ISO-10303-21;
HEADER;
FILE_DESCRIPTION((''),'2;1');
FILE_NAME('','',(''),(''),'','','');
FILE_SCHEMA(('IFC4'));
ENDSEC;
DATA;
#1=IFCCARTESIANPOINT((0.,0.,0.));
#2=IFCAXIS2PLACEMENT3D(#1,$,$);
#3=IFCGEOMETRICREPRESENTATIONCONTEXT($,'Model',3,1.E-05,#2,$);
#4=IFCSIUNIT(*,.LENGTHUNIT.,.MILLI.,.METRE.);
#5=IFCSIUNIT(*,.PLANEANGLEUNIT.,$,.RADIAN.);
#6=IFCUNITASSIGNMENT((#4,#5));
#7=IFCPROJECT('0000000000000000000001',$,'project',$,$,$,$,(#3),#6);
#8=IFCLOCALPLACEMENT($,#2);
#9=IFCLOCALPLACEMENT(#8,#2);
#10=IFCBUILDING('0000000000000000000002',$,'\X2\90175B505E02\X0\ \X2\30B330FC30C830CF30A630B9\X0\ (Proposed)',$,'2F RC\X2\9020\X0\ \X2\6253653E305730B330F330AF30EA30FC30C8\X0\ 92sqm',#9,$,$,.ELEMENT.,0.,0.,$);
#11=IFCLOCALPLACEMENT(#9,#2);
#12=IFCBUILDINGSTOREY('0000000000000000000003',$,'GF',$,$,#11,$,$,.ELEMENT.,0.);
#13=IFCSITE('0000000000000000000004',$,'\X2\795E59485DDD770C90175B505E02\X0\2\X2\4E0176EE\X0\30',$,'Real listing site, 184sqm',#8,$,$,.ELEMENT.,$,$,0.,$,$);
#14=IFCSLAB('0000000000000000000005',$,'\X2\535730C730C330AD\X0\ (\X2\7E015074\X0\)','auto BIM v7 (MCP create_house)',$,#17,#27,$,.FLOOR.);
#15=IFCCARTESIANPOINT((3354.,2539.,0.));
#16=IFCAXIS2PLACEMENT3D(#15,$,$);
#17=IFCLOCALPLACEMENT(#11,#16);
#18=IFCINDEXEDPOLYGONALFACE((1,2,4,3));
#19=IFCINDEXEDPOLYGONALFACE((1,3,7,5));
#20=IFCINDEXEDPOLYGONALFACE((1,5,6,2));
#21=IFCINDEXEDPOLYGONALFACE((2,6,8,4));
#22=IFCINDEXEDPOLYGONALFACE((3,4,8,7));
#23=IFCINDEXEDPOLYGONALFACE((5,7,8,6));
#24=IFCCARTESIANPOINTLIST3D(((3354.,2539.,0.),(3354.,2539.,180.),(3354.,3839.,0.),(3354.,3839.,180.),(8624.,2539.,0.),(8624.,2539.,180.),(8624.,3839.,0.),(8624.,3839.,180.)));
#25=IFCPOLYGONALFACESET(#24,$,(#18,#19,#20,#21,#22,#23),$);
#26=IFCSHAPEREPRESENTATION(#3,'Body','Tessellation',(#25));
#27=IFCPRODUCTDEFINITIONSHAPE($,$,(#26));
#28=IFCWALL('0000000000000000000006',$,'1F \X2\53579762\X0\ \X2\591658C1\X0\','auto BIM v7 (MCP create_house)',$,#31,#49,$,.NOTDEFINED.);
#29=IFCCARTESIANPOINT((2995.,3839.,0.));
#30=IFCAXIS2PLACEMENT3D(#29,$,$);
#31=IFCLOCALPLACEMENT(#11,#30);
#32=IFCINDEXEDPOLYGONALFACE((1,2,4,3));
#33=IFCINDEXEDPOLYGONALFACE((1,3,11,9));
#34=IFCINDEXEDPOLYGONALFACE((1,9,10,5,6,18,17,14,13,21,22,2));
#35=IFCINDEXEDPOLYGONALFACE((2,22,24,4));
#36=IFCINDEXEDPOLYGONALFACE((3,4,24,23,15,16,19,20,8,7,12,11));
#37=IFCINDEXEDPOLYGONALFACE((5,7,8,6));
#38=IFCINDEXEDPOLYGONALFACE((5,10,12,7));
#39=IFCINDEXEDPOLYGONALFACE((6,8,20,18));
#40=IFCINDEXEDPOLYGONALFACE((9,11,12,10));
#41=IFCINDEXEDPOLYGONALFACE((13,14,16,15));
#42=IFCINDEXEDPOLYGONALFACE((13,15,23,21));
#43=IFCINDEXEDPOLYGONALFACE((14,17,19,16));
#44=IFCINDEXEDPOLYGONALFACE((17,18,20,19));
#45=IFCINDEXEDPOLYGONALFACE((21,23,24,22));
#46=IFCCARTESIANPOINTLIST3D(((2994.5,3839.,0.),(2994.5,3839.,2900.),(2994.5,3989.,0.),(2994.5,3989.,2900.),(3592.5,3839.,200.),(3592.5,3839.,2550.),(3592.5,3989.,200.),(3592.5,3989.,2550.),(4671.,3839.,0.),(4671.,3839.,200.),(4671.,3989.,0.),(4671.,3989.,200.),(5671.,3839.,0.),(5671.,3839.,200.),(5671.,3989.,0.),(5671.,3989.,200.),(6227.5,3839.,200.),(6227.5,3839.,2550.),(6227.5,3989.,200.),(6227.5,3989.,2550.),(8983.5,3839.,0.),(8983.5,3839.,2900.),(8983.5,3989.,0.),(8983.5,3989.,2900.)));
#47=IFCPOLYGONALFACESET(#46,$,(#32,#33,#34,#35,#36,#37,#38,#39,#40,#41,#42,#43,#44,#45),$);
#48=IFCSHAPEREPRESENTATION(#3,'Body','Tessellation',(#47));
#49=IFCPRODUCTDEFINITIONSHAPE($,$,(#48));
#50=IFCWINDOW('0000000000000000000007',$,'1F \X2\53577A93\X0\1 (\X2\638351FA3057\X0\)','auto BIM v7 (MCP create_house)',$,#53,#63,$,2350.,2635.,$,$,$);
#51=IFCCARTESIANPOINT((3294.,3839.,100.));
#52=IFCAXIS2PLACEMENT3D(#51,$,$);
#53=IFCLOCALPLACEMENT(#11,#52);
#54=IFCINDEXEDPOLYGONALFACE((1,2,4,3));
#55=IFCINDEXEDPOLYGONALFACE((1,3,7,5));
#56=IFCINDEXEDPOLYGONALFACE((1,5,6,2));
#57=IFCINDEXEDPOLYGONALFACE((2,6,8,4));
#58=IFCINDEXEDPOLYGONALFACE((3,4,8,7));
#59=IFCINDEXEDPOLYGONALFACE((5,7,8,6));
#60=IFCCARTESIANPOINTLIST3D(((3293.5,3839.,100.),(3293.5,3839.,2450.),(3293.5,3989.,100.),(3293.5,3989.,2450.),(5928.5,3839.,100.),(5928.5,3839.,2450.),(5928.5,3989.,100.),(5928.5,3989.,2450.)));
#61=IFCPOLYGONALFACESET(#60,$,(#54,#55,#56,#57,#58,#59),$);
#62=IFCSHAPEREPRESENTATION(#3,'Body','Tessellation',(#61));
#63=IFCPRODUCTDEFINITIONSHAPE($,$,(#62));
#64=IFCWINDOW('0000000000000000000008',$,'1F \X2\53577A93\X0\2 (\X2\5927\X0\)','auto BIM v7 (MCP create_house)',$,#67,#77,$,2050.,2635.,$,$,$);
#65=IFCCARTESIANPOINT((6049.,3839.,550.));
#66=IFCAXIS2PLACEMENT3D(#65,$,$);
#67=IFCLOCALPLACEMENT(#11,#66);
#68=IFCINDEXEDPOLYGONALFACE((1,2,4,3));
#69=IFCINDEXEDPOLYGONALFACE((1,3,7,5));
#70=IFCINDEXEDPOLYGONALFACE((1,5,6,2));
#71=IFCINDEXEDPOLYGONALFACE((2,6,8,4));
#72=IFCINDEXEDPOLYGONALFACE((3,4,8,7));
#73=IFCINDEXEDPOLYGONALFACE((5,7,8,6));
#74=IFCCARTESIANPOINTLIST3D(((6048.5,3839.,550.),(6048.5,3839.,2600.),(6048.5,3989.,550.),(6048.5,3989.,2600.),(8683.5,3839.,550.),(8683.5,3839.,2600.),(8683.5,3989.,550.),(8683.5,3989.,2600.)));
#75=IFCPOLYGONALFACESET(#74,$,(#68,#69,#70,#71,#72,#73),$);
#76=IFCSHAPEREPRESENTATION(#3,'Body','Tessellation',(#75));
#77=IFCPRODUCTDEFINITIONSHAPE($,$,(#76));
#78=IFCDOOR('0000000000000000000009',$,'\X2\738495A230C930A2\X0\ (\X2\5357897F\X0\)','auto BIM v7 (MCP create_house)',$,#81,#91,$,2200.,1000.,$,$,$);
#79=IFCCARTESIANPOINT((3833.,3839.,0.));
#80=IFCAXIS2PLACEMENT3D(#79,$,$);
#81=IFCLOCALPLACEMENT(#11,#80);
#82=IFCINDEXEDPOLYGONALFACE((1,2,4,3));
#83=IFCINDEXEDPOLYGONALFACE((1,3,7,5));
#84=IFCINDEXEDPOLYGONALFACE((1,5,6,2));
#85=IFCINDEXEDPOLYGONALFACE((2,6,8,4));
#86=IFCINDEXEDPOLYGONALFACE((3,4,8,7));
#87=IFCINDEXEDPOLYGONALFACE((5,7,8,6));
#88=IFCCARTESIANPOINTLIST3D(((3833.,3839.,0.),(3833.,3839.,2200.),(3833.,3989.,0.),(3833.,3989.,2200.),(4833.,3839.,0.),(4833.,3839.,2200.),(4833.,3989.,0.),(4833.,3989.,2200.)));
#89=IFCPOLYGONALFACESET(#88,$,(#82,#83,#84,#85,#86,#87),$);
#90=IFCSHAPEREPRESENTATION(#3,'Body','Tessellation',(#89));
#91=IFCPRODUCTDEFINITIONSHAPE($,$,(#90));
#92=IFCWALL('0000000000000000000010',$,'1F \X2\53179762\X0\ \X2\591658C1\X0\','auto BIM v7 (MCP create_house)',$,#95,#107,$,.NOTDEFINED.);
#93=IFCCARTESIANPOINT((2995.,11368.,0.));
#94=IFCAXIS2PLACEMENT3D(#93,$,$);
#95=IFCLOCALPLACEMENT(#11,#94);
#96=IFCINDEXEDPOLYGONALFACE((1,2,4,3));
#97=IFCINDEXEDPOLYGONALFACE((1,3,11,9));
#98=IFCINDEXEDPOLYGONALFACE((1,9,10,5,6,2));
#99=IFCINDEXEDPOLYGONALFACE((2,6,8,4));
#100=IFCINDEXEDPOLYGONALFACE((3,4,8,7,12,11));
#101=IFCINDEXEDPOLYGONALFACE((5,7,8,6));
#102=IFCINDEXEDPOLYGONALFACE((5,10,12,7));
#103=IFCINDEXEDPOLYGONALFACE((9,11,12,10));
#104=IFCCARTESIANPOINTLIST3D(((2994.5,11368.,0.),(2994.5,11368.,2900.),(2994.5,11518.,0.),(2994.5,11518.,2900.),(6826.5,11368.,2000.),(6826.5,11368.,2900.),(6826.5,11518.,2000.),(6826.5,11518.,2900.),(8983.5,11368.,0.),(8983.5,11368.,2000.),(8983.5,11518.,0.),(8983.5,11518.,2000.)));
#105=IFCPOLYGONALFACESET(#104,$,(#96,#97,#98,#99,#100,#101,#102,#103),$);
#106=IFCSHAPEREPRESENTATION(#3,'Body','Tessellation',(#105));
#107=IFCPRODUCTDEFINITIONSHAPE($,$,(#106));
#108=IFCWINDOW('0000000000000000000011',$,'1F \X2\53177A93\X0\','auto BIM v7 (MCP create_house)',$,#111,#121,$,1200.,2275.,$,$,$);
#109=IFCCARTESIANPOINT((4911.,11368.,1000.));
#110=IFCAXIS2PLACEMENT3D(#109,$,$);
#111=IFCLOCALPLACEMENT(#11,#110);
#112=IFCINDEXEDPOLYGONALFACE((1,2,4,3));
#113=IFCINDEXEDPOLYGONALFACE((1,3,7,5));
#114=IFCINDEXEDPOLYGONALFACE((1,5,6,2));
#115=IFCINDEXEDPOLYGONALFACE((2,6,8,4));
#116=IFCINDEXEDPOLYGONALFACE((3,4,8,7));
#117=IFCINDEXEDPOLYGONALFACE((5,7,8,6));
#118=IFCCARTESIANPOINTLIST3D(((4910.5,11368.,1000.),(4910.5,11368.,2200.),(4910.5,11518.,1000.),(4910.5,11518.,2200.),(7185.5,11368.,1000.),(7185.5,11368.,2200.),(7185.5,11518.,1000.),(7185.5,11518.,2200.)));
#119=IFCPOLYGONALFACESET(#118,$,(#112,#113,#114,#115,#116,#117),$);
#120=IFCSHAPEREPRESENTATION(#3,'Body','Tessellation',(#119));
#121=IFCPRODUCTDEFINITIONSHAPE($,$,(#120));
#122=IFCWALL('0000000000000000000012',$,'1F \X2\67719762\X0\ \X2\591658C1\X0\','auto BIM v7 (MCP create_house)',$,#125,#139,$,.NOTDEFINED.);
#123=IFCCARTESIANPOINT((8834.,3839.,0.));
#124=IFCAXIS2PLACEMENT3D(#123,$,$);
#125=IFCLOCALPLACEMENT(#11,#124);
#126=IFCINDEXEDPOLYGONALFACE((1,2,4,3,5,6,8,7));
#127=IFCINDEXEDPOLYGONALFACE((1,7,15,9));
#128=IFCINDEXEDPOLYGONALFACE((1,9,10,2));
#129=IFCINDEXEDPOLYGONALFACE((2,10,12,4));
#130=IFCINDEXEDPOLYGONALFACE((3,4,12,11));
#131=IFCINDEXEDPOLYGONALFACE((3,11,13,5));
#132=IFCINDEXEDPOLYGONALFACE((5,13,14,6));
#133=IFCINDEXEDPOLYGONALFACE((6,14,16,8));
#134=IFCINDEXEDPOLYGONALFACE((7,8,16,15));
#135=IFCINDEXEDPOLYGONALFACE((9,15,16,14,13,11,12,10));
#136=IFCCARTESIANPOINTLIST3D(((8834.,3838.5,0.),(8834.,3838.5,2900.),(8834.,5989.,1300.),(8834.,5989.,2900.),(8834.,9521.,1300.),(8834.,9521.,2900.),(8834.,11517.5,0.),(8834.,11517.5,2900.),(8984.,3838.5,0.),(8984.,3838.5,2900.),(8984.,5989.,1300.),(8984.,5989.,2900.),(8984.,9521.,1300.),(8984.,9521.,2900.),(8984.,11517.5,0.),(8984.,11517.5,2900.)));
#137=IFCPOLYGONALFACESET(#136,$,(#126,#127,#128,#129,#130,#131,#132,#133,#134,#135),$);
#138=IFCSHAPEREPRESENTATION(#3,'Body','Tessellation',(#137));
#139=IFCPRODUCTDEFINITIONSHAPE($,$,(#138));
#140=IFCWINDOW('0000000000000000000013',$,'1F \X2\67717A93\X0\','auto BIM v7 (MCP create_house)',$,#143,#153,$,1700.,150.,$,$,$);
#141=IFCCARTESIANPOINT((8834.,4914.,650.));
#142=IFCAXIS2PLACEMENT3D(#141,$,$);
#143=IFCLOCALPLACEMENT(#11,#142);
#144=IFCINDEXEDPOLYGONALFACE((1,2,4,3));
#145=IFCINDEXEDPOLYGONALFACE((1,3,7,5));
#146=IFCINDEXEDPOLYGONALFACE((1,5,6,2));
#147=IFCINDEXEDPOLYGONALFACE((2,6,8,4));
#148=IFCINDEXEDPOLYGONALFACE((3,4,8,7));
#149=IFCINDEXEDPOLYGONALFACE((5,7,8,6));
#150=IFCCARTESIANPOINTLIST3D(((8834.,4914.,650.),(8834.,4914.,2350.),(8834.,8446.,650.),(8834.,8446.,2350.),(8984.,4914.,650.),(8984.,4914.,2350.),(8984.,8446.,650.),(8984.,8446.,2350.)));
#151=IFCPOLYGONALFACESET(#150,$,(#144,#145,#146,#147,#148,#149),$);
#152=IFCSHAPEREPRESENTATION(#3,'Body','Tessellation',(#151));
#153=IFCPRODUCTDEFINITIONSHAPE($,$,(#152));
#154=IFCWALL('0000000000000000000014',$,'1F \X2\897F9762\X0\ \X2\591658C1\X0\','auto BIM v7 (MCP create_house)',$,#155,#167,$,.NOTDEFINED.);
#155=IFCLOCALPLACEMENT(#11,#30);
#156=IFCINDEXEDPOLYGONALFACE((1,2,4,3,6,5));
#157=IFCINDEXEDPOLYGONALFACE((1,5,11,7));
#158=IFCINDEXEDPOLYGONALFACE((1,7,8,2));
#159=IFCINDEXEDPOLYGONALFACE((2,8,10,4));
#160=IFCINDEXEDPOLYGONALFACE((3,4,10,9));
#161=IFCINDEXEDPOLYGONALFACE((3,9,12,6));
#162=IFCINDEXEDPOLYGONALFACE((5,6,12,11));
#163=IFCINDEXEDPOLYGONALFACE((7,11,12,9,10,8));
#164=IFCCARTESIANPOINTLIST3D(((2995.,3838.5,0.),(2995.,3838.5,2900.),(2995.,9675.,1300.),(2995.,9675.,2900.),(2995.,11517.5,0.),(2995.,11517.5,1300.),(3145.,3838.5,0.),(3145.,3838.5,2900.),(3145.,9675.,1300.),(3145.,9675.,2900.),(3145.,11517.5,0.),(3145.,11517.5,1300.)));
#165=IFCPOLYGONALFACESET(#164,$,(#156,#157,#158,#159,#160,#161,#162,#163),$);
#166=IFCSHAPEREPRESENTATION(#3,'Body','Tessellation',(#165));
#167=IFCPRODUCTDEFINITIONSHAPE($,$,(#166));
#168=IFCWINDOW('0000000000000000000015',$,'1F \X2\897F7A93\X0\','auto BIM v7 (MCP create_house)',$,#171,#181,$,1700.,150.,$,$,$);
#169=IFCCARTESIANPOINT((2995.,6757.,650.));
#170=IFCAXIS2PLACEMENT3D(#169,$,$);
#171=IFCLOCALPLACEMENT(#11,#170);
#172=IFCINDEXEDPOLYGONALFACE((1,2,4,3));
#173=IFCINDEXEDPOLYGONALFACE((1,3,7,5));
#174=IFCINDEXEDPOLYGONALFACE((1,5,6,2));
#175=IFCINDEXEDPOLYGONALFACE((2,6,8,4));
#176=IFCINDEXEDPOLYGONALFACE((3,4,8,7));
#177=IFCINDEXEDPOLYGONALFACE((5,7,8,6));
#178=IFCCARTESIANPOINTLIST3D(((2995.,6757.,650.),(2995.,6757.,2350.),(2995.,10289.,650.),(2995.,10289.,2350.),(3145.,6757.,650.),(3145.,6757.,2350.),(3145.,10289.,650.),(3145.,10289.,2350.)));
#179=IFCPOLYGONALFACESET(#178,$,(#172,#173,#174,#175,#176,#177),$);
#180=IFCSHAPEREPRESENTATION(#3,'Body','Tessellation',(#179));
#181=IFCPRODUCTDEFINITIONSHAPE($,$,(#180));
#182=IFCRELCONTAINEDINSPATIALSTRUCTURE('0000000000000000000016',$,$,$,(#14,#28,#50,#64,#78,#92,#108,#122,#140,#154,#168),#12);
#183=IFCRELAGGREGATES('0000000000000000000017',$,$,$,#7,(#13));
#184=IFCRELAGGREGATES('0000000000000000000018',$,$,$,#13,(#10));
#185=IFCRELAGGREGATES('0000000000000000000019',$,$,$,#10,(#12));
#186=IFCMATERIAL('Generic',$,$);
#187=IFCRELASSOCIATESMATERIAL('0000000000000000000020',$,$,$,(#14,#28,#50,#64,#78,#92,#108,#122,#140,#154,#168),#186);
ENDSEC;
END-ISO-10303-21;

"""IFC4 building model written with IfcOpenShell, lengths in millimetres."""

from ifc_helpers import new_model, si_unit, frame, frame_2d, origin, place, context, project, spatial, rectangle, extrude, material, element, fill, save


model = new_model("IFC4")

# Units and contexts
model_context = context("Model", 3, precision=1e-05, world=origin())
ifc_project = project(units=[si_unit("LENGTHUNIT", "METRE", prefix="MILLI"), si_unit("PLANEANGLEUNIT", "RADIAN")], contexts=[model_context])

# Site, building, storey
site_placement = place(None, origin())
site = spatial("IfcSite", under=ifc_project, at=site_placement, Name="神奈川県逗子市2丁目30", ObjectType="Real listing site, 184sqm", CompositionType="ELEMENT", RefElevation=0.0)
building_placement = place(site_placement, origin())
building = spatial("IfcBuilding", under=site, at=building_placement, Name="逗子市 コートハウス (Proposed)", ObjectType="2F RC造 打放しコンクリート 92sqm", CompositionType="ELEMENT", ElevationOfRefHeight=0.0, ElevationOfTerrain=0.0)
storey_placement = place(building_placement, origin())
storey = spatial("IfcBuildingStorey", under=building, at=storey_placement, Name="GF", CompositionType="ELEMENT", Elevation=0.0)

# Slab
ifc_material = material(Name="Generic")
slab_1_placement = place(storey_placement, frame((3354.0, 2539.0, 0.0)))
element("IfcSlab", 1, at=slab_1_placement, inside=storey, material=ifc_material, Name="南デッキ (縁側)", Description="auto BIM v7 (MCP create_house)", PredefinedType="FLOOR", context=model_context, shape_type="SweptSolid", body=[
    extrude(rectangle(XDim=5270.0, YDim=1300.0, at=frame_2d((2635.0, 650.0))), frame((3354.0, 2539.0, 0.0)), (0.0, 0.0, 1.0), 180.0),
])

# Wall, openings, windows, door
wall_1_placement = place(storey_placement, frame((2995.0, 3839.0, 0.0)))
wall_1 = element("IfcWall", 2, at=wall_1_placement, inside=storey, material=ifc_material, Name="1F 南面 外壁", Description="auto BIM v7 (MCP create_house)", PredefinedType="NOTDEFINED", context=model_context, shape_type="SweptSolid", body=[
    extrude(rectangle(XDim=5989.0, YDim=150.0, at=frame_2d((2994.0, 75.0))), frame((2995.0, 3839.0, 0.0)), (0.0, 0.0, 1.0), 2900.0),
])
opening_1_placement = place(storey_placement, frame((3294.0, 3839.0, 100.0)))
opening_1 = element("IfcOpeningElement", 3, at=opening_1_placement, cuts=wall_1, PredefinedType="NOTDEFINED", context=model_context, shape_type="SweptSolid", body=[
    extrude(rectangle(XDim=2635.0, YDim=150.0, at=frame_2d((1317.0, 75.0))), frame((3294.0, 3839.0, 100.0)), (0.0, 0.0, 1.0), 2350.0),
])
opening_2_placement = place(storey_placement, frame((6049.0, 3839.0, 550.0)))
opening_2 = element("IfcOpeningElement", 4, at=opening_2_placement, cuts=wall_1, PredefinedType="NOTDEFINED", context=model_context, shape_type="SweptSolid", body=[
    extrude(rectangle(XDim=2635.0, YDim=150.0, at=frame_2d((1317.0, 75.0))), frame((6049.0, 3839.0, 550.0)), (0.0, 0.0, 1.0), 2050.0),
])
opening_3_placement = place(storey_placement, frame((3833.0, 3839.0, 0.0)))
opening_3 = element("IfcOpeningElement", 5, at=opening_3_placement, cuts=wall_1, PredefinedType="NOTDEFINED", context=model_context, shape_type="SweptSolid", body=[
    extrude(rectangle(XDim=1000.0, YDim=150.0, at=frame_2d((500.0, 75.0))), frame((3833.0, 3839.0, 0.0)), (0.0, 0.0, 1.0), 2200.0),
])
window_1_placement = place(storey_placement, frame((3294.0, 3839.0, 100.0)))
window_1 = element("IfcWindow", 6, at=window_1_placement, inside=storey, material=ifc_material, Name="1F 南窓1 (掃出し)", Description="auto BIM v7 (MCP create_house)", OverallHeight=2350.0, OverallWidth=2635.0, context=model_context, shape_type="SweptSolid", body=[
    extrude(rectangle(XDim=2635.0, YDim=150.0, at=frame_2d((1317.0, 75.0))), frame((3294.0, 3839.0, 100.0)), (0.0, 0.0, 1.0), 2350.0),
])
fill(opening_1, window_1)
window_2_placement = place(storey_placement, frame((6049.0, 3839.0, 550.0)))
window_2 = element("IfcWindow", 7, at=window_2_placement, inside=storey, material=ifc_material, Name="1F 南窓2 (大)", Description="auto BIM v7 (MCP create_house)", OverallHeight=2050.0, OverallWidth=2635.0, context=model_context, shape_type="SweptSolid", body=[
    extrude(rectangle(XDim=2635.0, YDim=150.0, at=frame_2d((1317.0, 75.0))), frame((6049.0, 3839.0, 550.0)), (0.0, 0.0, 1.0), 2050.0),
])
fill(opening_2, window_2)
door_placement = place(storey_placement, frame((3833.0, 3839.0, 0.0)))
door = element("IfcDoor", 8, at=door_placement, inside=storey, material=ifc_material, Name="玄関ドア (南西)", Description="auto BIM v7 (MCP create_house)", OverallHeight=2200.0, OverallWidth=1000.0, context=model_context, shape_type="SweptSolid", body=[
    extrude(rectangle(XDim=1000.0, YDim=150.0, at=frame_2d((500.0, 75.0))), frame((3833.0, 3839.0, 0.0)), (0.0, 0.0, 1.0), 2200.0),
])
fill(opening_3, door)

# Walls, openings, windows
wall_2_placement = place(storey_placement, frame((2995.0, 11368.0, 0.0)))
wall_2 = element("IfcWall", 9, at=wall_2_placement, inside=storey, material=ifc_material, Name="1F 北面 外壁", Description="auto BIM v7 (MCP create_house)", PredefinedType="NOTDEFINED", context=model_context, shape_type="SweptSolid", body=[
    extrude(rectangle(XDim=5989.0, YDim=150.0, at=frame_2d((2994.0, 75.0))), frame((2995.0, 11368.0, 0.0)), (0.0, 0.0, 1.0), 2900.0),
])
opening_4_placement = place(storey_placement, frame((4911.0, 11368.0, 1000.0)))
opening_4 = element("IfcOpeningElement", 10, at=opening_4_placement, cuts=wall_2, PredefinedType="NOTDEFINED", context=model_context, shape_type="SweptSolid", body=[
    extrude(rectangle(XDim=2275.0, YDim=150.0, at=frame_2d((1137.0, 75.0))), frame((4911.0, 11368.0, 1000.0)), (0.0, 0.0, 1.0), 1200.0),
])
window_3_placement = place(storey_placement, frame((4911.0, 11368.0, 1000.0)))
window_3 = element("IfcWindow", 11, at=window_3_placement, inside=storey, material=ifc_material, Name="1F 北窓", Description="auto BIM v7 (MCP create_house)", OverallHeight=1200.0, OverallWidth=2275.0, context=model_context, shape_type="SweptSolid", body=[
    extrude(rectangle(XDim=2275.0, YDim=150.0, at=frame_2d((1137.0, 75.0))), frame((4911.0, 11368.0, 1000.0)), (0.0, 0.0, 1.0), 1200.0),
])
fill(opening_4, window_3)
wall_3_placement = place(storey_placement, frame((8834.0, 3839.0, 0.0)))
wall_3 = element("IfcWall", 12, at=wall_3_placement, inside=storey, material=ifc_material, Name="1F 東面 外壁", Description="auto BIM v7 (MCP create_house)", PredefinedType="NOTDEFINED", context=model_context, shape_type="SweptSolid", body=[
    extrude(rectangle(XDim=150.0, YDim=7679.0, at=frame_2d((75.0, 3839.0))), frame((8834.0, 3839.0, 0.0)), (0.0, 0.0, 1.0), 2900.0),
])
opening_5_placement = place(storey_placement, frame((8834.0, 4914.0, 650.0)))
opening_5 = element("IfcOpeningElement", 13, at=opening_5_placement, cuts=wall_3, PredefinedType="NOTDEFINED", context=model_context, shape_type="SweptSolid", body=[
    extrude(rectangle(XDim=150.0, YDim=3532.0, at=frame_2d((75.0, 1766.0))), frame((8834.0, 4914.0, 650.0)), (0.0, 0.0, 1.0), 1700.0),
])
window_4_placement = place(storey_placement, frame((8834.0, 4914.0, 650.0)))
window_4 = element("IfcWindow", 14, at=window_4_placement, inside=storey, material=ifc_material, Name="1F 東窓", Description="auto BIM v7 (MCP create_house)", OverallHeight=1700.0, OverallWidth=150.0, context=model_context, shape_type="SweptSolid", body=[
    extrude(rectangle(XDim=150.0, YDim=3532.0, at=frame_2d((75.0, 1766.0))), frame((8834.0, 4914.0, 650.0)), (0.0, 0.0, 1.0), 1700.0),
])
fill(opening_5, window_4)
wall_4_placement = place(storey_placement, frame((2995.0, 3839.0, 0.0)))
wall_4 = element("IfcWall", 15, at=wall_4_placement, inside=storey, material=ifc_material, Name="1F 西面 外壁", Description="auto BIM v7 (MCP create_house)", PredefinedType="NOTDEFINED", context=model_context, shape_type="SweptSolid", body=[
    extrude(rectangle(XDim=150.0, YDim=7679.0, at=frame_2d((75.0, 3839.0))), frame((2995.0, 3839.0, 0.0)), (0.0, 0.0, 1.0), 2900.0),
])
opening_6_placement = place(storey_placement, frame((2995.0, 6757.0, 650.0)))
opening_6 = element("IfcOpeningElement", 16, at=opening_6_placement, cuts=wall_4, PredefinedType="NOTDEFINED", context=model_context, shape_type="SweptSolid", body=[
    extrude(rectangle(XDim=150.0, YDim=3532.0, at=frame_2d((75.0, 1766.0))), frame((2995.0, 6757.0, 650.0)), (0.0, 0.0, 1.0), 1700.0),
])
window_5_placement = place(storey_placement, frame((2995.0, 6757.0, 650.0)))
window_5 = element("IfcWindow", 17, at=window_5_placement, inside=storey, material=ifc_material, Name="1F 西窓", Description="auto BIM v7 (MCP create_house)", OverallHeight=1700.0, OverallWidth=150.0, context=model_context, shape_type="SweptSolid", body=[
    extrude(rectangle(XDim=150.0, YDim=3532.0, at=frame_2d((75.0, 1766.0))), frame((2995.0, 6757.0, 650.0)), (0.0, 0.0, 1.0), 1700.0),
])
fill(opening_6, window_5)

save(model, "model.ifc")
